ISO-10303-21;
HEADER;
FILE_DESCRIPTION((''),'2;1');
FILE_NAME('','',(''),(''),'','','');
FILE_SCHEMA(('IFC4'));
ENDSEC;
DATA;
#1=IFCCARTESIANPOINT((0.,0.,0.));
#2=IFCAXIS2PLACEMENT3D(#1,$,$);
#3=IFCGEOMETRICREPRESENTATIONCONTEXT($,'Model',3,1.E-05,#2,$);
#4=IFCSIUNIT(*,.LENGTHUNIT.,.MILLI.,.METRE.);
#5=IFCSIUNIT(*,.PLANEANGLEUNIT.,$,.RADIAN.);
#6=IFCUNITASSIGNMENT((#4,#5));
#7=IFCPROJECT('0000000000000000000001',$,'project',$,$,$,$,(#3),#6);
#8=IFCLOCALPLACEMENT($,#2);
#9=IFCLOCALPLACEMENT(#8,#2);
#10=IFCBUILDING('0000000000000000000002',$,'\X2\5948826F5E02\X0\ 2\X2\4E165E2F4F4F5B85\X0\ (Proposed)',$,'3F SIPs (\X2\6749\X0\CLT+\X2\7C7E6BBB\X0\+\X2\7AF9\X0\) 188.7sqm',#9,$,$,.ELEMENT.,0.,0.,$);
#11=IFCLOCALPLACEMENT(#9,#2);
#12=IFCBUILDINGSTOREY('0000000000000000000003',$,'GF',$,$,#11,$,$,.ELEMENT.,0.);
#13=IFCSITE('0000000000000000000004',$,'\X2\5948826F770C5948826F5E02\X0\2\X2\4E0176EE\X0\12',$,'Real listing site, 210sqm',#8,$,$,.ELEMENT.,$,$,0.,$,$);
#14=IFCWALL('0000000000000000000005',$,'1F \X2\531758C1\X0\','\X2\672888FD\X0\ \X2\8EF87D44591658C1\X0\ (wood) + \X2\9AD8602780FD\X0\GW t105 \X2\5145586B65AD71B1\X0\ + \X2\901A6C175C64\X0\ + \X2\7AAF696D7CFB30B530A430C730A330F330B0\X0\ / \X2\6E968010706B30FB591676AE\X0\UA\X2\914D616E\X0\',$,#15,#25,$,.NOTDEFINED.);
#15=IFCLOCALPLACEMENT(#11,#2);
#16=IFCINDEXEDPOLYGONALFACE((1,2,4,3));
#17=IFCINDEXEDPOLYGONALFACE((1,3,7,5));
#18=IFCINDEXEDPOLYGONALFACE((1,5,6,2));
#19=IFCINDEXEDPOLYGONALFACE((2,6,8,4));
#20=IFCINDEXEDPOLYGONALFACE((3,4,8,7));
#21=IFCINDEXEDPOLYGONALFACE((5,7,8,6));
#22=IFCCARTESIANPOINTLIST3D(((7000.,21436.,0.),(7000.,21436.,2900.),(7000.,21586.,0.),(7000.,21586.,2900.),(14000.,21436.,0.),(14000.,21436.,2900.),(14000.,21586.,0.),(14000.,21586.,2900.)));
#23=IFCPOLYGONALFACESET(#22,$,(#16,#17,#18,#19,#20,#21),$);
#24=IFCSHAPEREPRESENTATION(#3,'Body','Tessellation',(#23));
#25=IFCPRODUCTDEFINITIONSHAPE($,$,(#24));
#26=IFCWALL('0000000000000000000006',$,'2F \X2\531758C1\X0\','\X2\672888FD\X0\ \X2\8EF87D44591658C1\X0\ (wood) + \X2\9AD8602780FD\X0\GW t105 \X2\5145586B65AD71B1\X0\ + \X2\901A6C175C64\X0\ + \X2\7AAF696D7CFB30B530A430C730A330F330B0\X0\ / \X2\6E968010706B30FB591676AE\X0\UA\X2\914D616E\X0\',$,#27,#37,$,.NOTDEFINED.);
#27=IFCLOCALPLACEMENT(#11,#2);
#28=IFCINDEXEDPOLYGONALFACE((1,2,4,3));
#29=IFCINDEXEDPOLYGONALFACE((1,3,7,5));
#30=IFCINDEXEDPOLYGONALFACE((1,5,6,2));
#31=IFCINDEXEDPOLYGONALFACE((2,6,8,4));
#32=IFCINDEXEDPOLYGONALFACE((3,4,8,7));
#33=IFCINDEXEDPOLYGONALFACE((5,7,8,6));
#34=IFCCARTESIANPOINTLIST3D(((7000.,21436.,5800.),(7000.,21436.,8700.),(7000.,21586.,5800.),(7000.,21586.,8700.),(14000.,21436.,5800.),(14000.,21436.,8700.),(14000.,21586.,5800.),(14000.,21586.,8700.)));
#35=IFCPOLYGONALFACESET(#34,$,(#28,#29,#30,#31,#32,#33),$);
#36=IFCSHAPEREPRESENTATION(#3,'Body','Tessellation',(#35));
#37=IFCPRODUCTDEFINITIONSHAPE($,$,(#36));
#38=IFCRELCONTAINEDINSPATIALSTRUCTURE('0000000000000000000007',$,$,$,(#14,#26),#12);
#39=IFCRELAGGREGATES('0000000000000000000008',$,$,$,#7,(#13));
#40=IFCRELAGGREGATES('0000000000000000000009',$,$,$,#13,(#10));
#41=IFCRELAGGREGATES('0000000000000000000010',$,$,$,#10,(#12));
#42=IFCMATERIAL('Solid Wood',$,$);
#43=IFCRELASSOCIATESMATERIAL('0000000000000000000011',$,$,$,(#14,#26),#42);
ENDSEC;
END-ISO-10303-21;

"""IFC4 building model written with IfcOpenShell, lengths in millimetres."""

from ifc_helpers import new_model, si_unit, frame, frame_2d, origin, place, context, project, spatial, rectangle, extrude, material, element, save


model = new_model("IFC4")

# Units and contexts
model_context = context("Model", 3, precision=1e-05, world=origin())
ifc_project = project(units=[si_unit("LENGTHUNIT", "METRE", prefix="MILLI"), si_unit("PLANEANGLEUNIT", "RADIAN")], contexts=[model_context])

# Site, building, storey
site_placement = place(None, origin())
site = spatial("IfcSite", under=ifc_project, at=site_placement, Name="奈良県奈良市2丁目12", ObjectType="Real listing site, 210sqm", CompositionType="ELEMENT", RefElevation=0.0)
building_placement = place(site_placement, origin())
building = spatial("IfcBuilding", under=site, at=building_placement, Name="奈良市 2世帯住宅 (Proposed)", ObjectType="3F SIPs (杉CLT+籾殻+竹) 188.7sqm", CompositionType="ELEMENT", ElevationOfRefHeight=0.0, ElevationOfTerrain=0.0)
storey_placement = place(building_placement, origin())
storey = spatial("IfcBuildingStorey", under=building, at=storey_placement, Name="GF", CompositionType="ELEMENT", Elevation=0.0)

# Shared definitions
ifc_material_1 = material(Name="Solid Wood")

# Wall
wall_1_placement = place(storey_placement, frame((3500.0, 10718.0, 0.0)))
element("IfcWall", 1, at=wall_1_placement, inside=storey, material=ifc_material_1, Name="1F 北壁", Description="木製 軸組外壁 (wood) + 高性能GW t105 充填断熱 + 通気層 + 窯業系サイディング / 準耐火・外皮UA配慮", PredefinedType="NOTDEFINED", context=model_context, shape_type="SweptSolid", body=[
    extrude(rectangle(XDim=7000.0, YDim=150.0, at=frame_2d((3500.0, 75.0))), frame((3500.0, 10718.0, 0.0)), (0.0, 0.0, 1.0), 2900.0),
])

# Wall
wall_2_placement = place(storey_placement, frame((3500.0, 10718.0, 2900.0)))
element("IfcWall", 2, at=wall_2_placement, inside=storey, material=ifc_material_1, Name="2F 北壁", Description="木製 軸組外壁 (wood) + 高性能GW t105 充填断熱 + 通気層 + 窯業系サイディング / 準耐火・外皮UA配慮", PredefinedType="NOTDEFINED", context=model_context, shape_type="SweptSolid", body=[
    extrude(rectangle(XDim=7000.0, YDim=150.0, at=frame_2d((3500.0, 75.0))), frame((3500.0, 10718.0, 2900.0)), (0.0, 0.0, 1.0), 2900.0),
])

save(model, "model.ifc")
